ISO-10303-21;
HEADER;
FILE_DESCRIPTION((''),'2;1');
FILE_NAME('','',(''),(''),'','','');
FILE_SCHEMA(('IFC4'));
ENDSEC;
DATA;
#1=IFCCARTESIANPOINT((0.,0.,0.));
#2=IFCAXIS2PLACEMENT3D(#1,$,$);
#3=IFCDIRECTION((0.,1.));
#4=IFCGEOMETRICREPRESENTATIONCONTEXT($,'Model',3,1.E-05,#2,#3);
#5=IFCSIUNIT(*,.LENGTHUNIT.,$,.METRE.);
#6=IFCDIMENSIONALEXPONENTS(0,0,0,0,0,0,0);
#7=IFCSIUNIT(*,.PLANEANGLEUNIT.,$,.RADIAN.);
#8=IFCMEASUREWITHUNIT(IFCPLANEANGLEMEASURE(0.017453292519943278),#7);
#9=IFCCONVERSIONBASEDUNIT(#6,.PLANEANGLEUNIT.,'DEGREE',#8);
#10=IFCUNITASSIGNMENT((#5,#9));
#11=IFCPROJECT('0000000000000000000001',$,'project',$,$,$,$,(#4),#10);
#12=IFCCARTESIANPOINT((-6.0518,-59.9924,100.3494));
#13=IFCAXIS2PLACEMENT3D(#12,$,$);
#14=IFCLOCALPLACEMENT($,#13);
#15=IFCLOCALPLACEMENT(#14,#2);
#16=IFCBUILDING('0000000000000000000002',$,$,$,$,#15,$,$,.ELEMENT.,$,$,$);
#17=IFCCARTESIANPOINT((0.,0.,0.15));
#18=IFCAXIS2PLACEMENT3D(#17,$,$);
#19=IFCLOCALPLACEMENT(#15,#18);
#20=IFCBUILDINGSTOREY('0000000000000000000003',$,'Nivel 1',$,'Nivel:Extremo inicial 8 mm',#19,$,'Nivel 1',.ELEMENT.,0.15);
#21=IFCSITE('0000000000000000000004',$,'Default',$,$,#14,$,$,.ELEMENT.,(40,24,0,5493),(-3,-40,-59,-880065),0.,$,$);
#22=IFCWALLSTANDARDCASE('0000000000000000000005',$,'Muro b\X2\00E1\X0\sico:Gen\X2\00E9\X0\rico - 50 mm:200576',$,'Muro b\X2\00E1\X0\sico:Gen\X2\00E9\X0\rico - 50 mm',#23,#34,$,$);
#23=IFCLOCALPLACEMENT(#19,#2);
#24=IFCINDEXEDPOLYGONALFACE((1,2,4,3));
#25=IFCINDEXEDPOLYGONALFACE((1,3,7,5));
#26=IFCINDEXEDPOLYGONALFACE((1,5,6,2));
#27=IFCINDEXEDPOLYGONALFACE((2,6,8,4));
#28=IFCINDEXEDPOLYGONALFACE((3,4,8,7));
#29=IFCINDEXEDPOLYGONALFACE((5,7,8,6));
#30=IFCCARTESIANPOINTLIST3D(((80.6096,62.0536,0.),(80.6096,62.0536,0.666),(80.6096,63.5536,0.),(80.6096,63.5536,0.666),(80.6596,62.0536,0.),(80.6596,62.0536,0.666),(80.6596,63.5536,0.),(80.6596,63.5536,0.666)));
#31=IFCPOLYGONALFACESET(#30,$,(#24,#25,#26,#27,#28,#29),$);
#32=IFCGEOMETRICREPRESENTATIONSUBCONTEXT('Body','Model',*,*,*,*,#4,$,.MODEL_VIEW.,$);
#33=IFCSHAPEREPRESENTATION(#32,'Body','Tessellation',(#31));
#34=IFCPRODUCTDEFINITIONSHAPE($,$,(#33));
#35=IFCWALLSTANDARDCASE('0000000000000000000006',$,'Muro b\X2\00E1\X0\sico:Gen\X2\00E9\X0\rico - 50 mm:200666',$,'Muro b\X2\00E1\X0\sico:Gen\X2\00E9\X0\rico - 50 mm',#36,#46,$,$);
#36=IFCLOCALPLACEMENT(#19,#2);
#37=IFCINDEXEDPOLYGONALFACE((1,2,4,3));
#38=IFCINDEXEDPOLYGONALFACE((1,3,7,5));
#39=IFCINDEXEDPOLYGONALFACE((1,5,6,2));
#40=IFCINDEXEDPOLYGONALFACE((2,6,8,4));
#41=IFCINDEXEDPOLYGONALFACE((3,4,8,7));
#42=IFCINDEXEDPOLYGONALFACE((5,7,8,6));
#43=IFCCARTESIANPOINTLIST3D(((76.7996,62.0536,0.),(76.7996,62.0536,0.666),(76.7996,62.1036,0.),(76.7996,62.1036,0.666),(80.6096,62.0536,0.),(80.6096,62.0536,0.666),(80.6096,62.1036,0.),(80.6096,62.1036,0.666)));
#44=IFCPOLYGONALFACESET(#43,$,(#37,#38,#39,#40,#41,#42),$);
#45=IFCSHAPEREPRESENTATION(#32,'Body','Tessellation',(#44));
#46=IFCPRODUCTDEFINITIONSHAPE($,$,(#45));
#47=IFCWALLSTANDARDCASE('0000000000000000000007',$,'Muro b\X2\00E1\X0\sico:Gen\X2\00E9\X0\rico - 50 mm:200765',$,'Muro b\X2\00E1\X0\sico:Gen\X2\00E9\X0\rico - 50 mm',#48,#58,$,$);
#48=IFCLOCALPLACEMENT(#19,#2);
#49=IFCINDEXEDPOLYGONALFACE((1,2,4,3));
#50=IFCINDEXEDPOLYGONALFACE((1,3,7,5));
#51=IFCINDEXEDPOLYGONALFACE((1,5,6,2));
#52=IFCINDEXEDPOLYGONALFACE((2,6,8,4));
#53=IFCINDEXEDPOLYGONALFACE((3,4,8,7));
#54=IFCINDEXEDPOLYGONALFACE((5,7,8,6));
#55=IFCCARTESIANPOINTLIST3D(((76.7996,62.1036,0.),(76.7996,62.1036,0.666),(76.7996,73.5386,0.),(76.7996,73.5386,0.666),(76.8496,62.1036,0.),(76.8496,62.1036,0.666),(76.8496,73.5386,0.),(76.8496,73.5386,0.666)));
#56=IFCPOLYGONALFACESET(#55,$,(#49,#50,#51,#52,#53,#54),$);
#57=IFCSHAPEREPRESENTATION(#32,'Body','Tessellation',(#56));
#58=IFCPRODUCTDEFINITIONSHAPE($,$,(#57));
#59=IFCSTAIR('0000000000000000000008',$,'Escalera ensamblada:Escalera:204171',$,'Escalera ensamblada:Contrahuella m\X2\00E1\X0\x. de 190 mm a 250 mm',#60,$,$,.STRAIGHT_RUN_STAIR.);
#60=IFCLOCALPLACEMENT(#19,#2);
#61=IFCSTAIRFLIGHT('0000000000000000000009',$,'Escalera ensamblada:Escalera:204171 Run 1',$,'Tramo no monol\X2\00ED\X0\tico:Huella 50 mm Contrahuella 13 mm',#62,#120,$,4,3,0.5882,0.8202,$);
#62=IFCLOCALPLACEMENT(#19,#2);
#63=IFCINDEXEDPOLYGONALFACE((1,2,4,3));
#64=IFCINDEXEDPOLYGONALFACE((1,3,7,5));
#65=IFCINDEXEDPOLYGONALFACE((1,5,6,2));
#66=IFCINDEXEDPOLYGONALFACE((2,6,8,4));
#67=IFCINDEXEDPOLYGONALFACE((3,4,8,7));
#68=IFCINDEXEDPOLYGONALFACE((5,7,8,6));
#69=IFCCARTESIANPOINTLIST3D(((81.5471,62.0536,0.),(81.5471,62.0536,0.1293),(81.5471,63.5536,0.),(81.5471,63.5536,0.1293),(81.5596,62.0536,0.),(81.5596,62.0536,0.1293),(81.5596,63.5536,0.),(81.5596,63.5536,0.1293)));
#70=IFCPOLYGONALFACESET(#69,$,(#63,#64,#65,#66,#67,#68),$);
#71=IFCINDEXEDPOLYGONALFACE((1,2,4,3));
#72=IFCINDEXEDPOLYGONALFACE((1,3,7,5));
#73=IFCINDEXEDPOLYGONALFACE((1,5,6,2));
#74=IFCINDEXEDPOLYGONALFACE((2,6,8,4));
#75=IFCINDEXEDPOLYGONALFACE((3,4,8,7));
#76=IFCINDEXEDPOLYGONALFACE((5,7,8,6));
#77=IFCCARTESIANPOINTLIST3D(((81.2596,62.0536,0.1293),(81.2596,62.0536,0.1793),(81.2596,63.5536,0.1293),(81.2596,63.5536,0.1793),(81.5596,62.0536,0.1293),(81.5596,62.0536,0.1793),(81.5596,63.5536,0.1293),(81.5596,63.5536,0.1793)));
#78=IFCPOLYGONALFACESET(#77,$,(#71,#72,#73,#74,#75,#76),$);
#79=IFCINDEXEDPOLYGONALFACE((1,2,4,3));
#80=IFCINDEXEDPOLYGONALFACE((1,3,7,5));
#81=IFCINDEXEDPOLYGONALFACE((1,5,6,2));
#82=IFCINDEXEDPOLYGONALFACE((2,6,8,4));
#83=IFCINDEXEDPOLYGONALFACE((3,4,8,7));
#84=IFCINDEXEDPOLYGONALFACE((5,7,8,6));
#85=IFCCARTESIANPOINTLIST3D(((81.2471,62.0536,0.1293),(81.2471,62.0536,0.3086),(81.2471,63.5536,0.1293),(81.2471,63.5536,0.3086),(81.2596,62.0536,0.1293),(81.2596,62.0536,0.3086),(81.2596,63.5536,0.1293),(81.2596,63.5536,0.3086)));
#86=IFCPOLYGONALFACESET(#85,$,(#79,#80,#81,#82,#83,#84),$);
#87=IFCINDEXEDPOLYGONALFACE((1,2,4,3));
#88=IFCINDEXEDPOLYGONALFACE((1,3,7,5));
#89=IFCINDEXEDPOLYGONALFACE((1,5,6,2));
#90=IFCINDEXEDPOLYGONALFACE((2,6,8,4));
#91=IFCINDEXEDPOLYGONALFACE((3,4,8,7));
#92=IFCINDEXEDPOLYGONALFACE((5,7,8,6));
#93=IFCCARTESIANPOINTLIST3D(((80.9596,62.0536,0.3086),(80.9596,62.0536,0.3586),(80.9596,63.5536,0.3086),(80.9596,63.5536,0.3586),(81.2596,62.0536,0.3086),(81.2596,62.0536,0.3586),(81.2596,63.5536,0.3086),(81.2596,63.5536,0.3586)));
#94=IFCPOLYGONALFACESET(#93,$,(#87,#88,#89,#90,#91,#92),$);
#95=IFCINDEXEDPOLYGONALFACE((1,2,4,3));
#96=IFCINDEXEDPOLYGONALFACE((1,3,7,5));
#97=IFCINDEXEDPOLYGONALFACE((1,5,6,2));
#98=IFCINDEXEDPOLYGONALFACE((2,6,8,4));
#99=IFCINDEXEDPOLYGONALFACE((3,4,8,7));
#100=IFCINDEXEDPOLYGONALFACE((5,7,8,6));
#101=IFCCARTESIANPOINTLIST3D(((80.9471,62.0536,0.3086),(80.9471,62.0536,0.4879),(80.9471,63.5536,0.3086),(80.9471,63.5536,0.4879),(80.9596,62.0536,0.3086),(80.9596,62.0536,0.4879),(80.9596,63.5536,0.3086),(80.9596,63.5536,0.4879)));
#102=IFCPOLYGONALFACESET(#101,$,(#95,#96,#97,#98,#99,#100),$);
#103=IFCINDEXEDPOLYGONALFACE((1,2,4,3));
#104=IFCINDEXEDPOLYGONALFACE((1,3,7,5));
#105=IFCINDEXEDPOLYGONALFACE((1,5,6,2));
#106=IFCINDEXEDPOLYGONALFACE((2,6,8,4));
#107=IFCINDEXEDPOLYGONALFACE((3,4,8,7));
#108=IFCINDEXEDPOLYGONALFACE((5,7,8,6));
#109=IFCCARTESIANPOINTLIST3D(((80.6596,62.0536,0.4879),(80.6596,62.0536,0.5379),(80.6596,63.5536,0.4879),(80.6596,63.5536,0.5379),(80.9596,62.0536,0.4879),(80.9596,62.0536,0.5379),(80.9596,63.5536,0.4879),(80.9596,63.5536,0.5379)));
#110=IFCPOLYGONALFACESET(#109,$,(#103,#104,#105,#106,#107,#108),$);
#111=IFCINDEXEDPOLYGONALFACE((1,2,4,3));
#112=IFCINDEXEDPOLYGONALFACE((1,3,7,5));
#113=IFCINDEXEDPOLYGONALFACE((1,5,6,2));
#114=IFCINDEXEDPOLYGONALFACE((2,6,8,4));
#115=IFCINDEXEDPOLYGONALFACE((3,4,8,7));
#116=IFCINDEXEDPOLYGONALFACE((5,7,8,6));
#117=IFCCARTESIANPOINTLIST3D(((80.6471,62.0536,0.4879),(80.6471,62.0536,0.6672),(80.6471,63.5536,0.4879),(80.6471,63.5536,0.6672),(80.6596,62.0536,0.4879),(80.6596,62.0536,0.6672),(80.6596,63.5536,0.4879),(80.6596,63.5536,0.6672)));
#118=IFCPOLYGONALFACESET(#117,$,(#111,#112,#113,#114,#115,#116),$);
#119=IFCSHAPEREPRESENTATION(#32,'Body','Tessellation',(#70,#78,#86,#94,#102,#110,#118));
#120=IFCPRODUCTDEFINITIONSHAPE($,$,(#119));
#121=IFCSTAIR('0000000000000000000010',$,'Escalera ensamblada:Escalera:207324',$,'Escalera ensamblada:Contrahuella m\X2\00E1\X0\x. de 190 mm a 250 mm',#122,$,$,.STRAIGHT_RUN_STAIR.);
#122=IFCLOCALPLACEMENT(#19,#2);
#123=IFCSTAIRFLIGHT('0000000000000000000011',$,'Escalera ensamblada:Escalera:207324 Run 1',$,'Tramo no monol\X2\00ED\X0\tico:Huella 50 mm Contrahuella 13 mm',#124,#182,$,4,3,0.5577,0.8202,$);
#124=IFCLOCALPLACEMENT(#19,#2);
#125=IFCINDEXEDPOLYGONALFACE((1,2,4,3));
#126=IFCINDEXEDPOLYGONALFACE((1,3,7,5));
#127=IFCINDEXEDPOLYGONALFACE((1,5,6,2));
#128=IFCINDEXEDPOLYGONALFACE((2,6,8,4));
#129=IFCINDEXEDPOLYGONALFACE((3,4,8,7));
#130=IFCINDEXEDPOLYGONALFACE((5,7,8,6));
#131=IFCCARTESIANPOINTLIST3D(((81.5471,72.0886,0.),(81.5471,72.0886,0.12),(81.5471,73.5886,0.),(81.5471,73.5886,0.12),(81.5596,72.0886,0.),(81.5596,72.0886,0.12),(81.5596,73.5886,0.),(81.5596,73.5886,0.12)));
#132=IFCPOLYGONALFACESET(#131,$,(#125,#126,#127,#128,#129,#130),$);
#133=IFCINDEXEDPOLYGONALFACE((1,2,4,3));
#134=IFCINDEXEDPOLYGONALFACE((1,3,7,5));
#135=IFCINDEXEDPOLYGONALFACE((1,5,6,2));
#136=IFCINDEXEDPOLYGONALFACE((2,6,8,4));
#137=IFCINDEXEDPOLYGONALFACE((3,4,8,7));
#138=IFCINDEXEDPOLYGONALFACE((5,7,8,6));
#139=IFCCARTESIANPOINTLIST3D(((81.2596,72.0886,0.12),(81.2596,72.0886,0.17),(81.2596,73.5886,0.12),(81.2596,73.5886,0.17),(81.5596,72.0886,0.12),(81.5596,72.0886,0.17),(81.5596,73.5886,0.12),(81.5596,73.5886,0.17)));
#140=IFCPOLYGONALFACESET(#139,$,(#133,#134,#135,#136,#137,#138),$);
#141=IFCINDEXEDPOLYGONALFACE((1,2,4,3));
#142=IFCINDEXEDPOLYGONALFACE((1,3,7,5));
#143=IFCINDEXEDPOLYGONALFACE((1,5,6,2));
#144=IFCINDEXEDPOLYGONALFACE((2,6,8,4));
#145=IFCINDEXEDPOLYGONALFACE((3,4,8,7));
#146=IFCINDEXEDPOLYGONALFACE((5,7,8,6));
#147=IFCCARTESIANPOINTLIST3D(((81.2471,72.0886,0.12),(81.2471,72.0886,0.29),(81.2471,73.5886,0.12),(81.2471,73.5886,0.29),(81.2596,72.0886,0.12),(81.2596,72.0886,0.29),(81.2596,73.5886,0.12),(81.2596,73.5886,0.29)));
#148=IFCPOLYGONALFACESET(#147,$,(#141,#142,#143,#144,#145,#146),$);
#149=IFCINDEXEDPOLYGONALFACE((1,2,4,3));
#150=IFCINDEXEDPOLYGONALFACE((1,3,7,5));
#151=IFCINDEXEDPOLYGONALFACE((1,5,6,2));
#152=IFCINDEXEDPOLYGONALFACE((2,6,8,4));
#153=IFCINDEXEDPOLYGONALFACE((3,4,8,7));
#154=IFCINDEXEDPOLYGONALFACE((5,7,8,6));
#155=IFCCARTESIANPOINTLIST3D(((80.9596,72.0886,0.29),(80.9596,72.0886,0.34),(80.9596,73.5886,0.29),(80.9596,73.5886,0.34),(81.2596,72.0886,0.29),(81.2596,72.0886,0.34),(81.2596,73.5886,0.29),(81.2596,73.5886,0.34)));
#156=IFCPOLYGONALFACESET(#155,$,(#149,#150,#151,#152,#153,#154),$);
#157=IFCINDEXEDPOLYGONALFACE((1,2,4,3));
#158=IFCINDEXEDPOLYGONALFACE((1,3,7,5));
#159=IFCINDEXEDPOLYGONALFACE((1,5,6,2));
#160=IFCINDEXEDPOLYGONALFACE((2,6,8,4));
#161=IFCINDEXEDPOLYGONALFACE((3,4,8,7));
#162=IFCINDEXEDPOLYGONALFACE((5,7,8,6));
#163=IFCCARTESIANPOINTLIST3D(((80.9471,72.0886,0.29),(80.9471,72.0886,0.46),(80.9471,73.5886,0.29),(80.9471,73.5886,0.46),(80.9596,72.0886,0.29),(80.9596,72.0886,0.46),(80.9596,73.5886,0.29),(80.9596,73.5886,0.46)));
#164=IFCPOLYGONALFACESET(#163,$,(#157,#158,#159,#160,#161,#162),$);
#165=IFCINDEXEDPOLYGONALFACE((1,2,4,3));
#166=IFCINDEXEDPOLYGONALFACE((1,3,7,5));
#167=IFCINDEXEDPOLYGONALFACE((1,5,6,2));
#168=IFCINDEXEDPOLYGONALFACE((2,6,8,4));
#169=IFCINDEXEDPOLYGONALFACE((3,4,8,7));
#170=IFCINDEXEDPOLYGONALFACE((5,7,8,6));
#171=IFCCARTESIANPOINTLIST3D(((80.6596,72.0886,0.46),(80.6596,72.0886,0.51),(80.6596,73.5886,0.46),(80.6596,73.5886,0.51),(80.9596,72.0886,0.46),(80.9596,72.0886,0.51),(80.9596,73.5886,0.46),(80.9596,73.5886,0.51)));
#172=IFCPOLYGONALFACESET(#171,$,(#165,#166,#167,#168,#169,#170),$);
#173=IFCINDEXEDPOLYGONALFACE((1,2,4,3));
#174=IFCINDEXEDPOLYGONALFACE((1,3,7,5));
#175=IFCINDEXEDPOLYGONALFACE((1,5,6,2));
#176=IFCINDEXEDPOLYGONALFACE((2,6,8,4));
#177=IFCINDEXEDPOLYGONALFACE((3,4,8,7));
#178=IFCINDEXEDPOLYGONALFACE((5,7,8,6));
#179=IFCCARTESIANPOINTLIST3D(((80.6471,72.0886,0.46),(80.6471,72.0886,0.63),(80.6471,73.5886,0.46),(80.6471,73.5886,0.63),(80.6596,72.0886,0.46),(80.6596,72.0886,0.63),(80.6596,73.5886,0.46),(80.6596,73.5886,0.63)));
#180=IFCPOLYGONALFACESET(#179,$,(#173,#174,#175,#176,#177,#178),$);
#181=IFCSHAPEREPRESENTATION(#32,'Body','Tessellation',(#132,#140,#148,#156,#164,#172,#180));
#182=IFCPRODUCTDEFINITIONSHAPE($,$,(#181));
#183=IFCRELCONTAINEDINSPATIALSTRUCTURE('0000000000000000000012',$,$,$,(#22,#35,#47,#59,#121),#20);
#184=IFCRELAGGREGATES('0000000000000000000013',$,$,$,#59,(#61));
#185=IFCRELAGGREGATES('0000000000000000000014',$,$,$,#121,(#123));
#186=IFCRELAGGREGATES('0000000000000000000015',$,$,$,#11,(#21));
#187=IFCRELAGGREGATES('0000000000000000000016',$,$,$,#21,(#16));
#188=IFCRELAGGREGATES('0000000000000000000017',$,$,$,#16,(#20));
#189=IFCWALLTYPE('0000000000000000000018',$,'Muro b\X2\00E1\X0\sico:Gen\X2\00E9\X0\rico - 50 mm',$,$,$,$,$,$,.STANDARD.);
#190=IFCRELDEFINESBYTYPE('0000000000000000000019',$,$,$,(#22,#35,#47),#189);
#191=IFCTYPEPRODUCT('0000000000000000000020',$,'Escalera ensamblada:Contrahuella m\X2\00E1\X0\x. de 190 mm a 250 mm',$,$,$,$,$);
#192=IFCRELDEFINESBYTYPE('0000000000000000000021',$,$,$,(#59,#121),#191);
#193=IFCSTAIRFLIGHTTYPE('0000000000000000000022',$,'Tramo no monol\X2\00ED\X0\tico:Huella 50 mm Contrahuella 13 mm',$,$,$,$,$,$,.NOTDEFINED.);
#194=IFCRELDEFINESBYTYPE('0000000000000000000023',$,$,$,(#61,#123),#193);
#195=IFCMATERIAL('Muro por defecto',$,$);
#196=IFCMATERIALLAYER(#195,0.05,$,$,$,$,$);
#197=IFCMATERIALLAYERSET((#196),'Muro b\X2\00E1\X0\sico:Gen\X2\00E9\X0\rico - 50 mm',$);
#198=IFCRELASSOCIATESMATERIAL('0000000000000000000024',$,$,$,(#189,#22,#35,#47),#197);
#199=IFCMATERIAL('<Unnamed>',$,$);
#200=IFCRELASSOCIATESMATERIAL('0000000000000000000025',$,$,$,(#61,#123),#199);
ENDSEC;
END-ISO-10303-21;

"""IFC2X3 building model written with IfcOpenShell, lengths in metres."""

from ifc_helpers import new_model, entity, si_unit, converted_unit, direction, frame, frame_2d, origin, origin_2d_with_axis, place, context, subcontext, project, spatial, polyline, rectangle, extrude, clip, bounded_halfspace, material, layer, layer_set, layer_usage, type_object, element, aggregate, save


model = new_model("IFC2X3")

# Units and contexts
model_context = context("Model", 3, precision=1e-05, world=origin(), true_north=direction((0.0, 1.0)))
body_context = subcontext(model_context, "Body", "Model", "MODEL_VIEW")
ifc_project = project(units=[si_unit("LENGTHUNIT", "METRE"), converted_unit("PLANEANGLEUNIT", "DEGREE", entity("IfcPlaneAngleMeasure", 0.017453292519943278), si_unit("PLANEANGLEUNIT", "RADIAN"), dimensions=[0, 0, 0, 0, 0, 0, 0])], contexts=[model_context])

# Site, building, storey
site_placement = place(None, frame((-6.0518, -59.9924, 100.3494)))
site = spatial("IfcSite", under=ifc_project, at=site_placement, Name="Default", CompositionType="ELEMENT", RefLatitude=(40, 24, 0, 5493), RefLongitude=(-3, -40, -59, -880065), RefElevation=0.0)
building_placement = place(site_placement, origin())
building = spatial("IfcBuilding", under=site, at=building_placement, CompositionType="ELEMENT")
storey_placement = place(building_placement, frame((0.0, 0.0, 0.15)))
storey = spatial("IfcBuildingStorey", under=building, at=storey_placement, Name="Nivel 1", ObjectType="Nivel:Extremo inicial 8 mm", LongName="Nivel 1", CompositionType="ELEMENT", Elevation=0.15)

# Walls
ifc_material_1 = material(Name="Muro por defecto")
ifc_layer_1 = layer(ifc_material_1, 0.05)
ifc_layer_set_1 = layer_set([ifc_layer_1], Name="Muro básico:Genérico - 50 mm")
wall_type = type_object("IfcWallType", Name="Muro básico:Genérico - 50 mm", PredefinedType="STANDARD", material=ifc_layer_set_1)
ifc_layer_usage_1 = layer_usage(ifc_layer_set_1, "AXIS2", "POSITIVE", -0.025)
wall_1_placement = place(storey_placement, frame((80.6346, 63.5536, 0.0), z_axis=(0.0, 0.0, 1.0), x_axis=(0.0, -1.0, 0.0)))
element("IfcWallStandardCase", 1, at=wall_1_placement, inside=storey, type_object=wall_type, material=ifc_layer_usage_1, Name="Muro básico:Genérico - 50 mm:200576", ObjectType="Muro básico:Genérico - 50 mm", context=body_context, shape_type="Clipping", body=[
    clip(extrude(rectangle(XDim=1.5, YDim=0.05, at=frame_2d((0.75, 0.0), x_axis=(-1.0, 0.0))), origin(), (0.0, 0.0, 1.0), 0.666), bounded_halfspace(frame((0.0, -0.025, 0.666), z_axis=(0.0, 0.0, -1.0), x_axis=(0.0, 1.0, 0.0)), True, frame((0.0, -0.025, 0.666), z_axis=(0.0, 0.0, -1.0), x_axis=(0.0, 1.0, 0.0)), polyline([(0.0, 0.0), (0.05, 0.0), (0.05, 1.5), (0.0, 1.5), (0.0, 0.0)]))),
])
ifc_layer_usage_2 = layer_usage(ifc_layer_set_1, "AXIS2", "POSITIVE", -0.025)
wall_2_placement = place(storey_placement, frame((80.6096, 62.0786, 0.0), z_axis=(0.0, 0.0, 1.0), x_axis=(-1.0, 0.0, 0.0)))
element("IfcWallStandardCase", 2, at=wall_2_placement, inside=storey, type_object=wall_type, material=ifc_layer_usage_2, Name="Muro básico:Genérico - 50 mm:200666", ObjectType="Muro básico:Genérico - 50 mm", context=body_context, shape_type="Clipping", body=[
    clip(extrude(rectangle(XDim=3.81, YDim=0.05, at=frame_2d((1.905, 0.0), x_axis=(-1.0, 0.0))), origin(), (0.0, 0.0, 1.0), 0.666), bounded_halfspace(frame((0.0, -0.025, 0.666), z_axis=(0.0, 0.0, -1.0), x_axis=(-1.0, 0.0, 0.0)), True, frame((0.0, -0.025, 0.666), z_axis=(0.0, 0.0, -1.0), x_axis=(-1.0, 0.0, 0.0)), polyline([(0.0, 0.0), (0.0, 0.05), (-3.81, 0.05), (-3.81, 0.0), (-3.76, 0.0), (0.0, 0.0)]))),
])
ifc_layer_usage_3 = layer_usage(ifc_layer_set_1, "AXIS2", "POSITIVE", -0.025)
wall_3_placement = place(storey_placement, frame((76.8246, 62.1036, 0.0), z_axis=(0.0, 0.0, 1.0), x_axis=(0.0, 1.0, 0.0)))
element("IfcWallStandardCase", 3, at=wall_3_placement, inside=storey, type_object=wall_type, material=ifc_layer_usage_3, Name="Muro básico:Genérico - 50 mm:200765", ObjectType="Muro básico:Genérico - 50 mm", context=body_context, shape_type="Clipping", body=[
    clip(extrude(rectangle(XDim=11.435, YDim=0.05, at=frame_2d((5.7175, 0.0), x_axis=(-1.0, 0.0))), origin(), (0.0, 0.0, 1.0), 0.666), bounded_halfspace(frame((0.0, -0.025, 0.666), z_axis=(0.0, 0.0, -1.0), x_axis=(0.0, -1.0, 0.0)), True, frame((0.0, -0.025, 0.666), z_axis=(0.0, 0.0, -1.0), x_axis=(0.0, -1.0, 0.0)), polyline([(0.0, 0.0), (-0.05, 0.0), (-0.05, -11.435), (0.0, -11.435), (0.0, 0.0)]))),
])

# Stairs, stair flights
type_product = type_object("IfcTypeProduct", Name="Escalera ensamblada:Contrahuella máx. de 190 mm a 250 mm")
stair_1_placement = place(storey_placement, origin())
stair_1 = element("IfcStair", 4, at=stair_1_placement, inside=storey, type_object=type_product, Name="Escalera ensamblada:Escalera:204171", ObjectType="Escalera ensamblada:Contrahuella máx. de 190 mm a 250 mm", ShapeType="STRAIGHT_RUN_STAIR")
ifc_material_2 = material(Name="<Unnamed>")
stair_flight_type = type_object("IfcStairFlightType", Name="Tramo no monolítico:Huella 50 mm Contrahuella 13 mm", PredefinedType="NOTDEFINED")
stair_flight_1_placement = place(stair_1_placement, origin())
stair_flight_1 = element("IfcStairFlight", 5, at=stair_flight_1_placement, type_object=stair_flight_type, material=ifc_material_2, Name="Escalera ensamblada:Escalera:204171 Run 1", ObjectType="Tramo no monolítico:Huella 50 mm Contrahuella 13 mm", NumberOfRiser=4, NumberOfTreads=3, RiserHeight=0.5882, TreadLength=0.8202, context=body_context, shape_type="SweptSolid", body=[
    extrude(rectangle(XDim=1.5, YDim=0.0125, at=origin_2d_with_axis()), frame((81.5534, 62.8036, 0.0), z_axis=(0.0, 0.0, 1.0), x_axis=(0.0, -1.0, 0.0)), (0.0, 0.0, 1.0), 0.1293),
    extrude(rectangle(XDim=0.3, YDim=1.5, at=frame_2d((0.0, 0.0), x_axis=(1.0, 0.0))), frame((81.4096, 62.8036, 0.1293)), (0.0, 0.0, 1.0), 0.05),
    extrude(rectangle(XDim=1.5, YDim=0.0125, at=origin_2d_with_axis()), frame((81.2534, 62.8036, 0.1293), z_axis=(0.0, 0.0, 1.0), x_axis=(0.0, -1.0, 0.0)), (0.0, 0.0, 1.0), 0.1793),
    extrude(rectangle(XDim=0.3, YDim=1.5, at=frame_2d((0.0, 0.0), x_axis=(1.0, 0.0))), frame((81.1096, 62.8036, 0.3086)), (0.0, 0.0, 1.0), 0.05),
    extrude(rectangle(XDim=1.5, YDim=0.0125, at=origin_2d_with_axis()), frame((80.9534, 62.8036, 0.3086), z_axis=(0.0, 0.0, 1.0), x_axis=(0.0, -1.0, 0.0)), (0.0, 0.0, 1.0), 0.1793),
    extrude(rectangle(XDim=0.3, YDim=1.5, at=frame_2d((0.0, 0.0), x_axis=(1.0, 0.0))), frame((80.8096, 62.8036, 0.4879)), (0.0, 0.0, 1.0), 0.05),
    extrude(rectangle(XDim=1.5, YDim=0.0125, at=origin_2d_with_axis()), frame((80.6534, 62.8036, 0.4879), z_axis=(0.0, 0.0, 1.0), x_axis=(0.0, -1.0, 0.0)), (0.0, 0.0, 1.0), 0.1793),
])
aggregate(stair_1, [stair_flight_1])
stair_2_placement = place(storey_placement, origin())
stair_2 = element("IfcStair", 6, at=stair_2_placement, inside=storey, type_object=type_product, Name="Escalera ensamblada:Escalera:207324", ObjectType="Escalera ensamblada:Contrahuella máx. de 190 mm a 250 mm", ShapeType="STRAIGHT_RUN_STAIR")
stair_flight_2_placement = place(stair_2_placement, origin())
stair_flight_2 = element("IfcStairFlight", 7, at=stair_flight_2_placement, type_object=stair_flight_type, material=ifc_material_2, Name="Escalera ensamblada:Escalera:207324 Run 1", ObjectType="Tramo no monolítico:Huella 50 mm Contrahuella 13 mm", NumberOfRiser=4, NumberOfTreads=3, RiserHeight=0.5577, TreadLength=0.8202, context=body_context, shape_type="SweptSolid", body=[
    extrude(rectangle(XDim=1.5, YDim=0.0125, at=origin_2d_with_axis()), frame((81.5534, 72.8386, 0.0), z_axis=(0.0, 0.0, 1.0), x_axis=(0.0, -1.0, 0.0)), (0.0, 0.0, 1.0), 0.12),
    extrude(rectangle(XDim=0.3, YDim=1.5, at=frame_2d((0.0, 0.0), x_axis=(1.0, 0.0))), frame((81.4096, 72.8386, 0.12)), (0.0, 0.0, 1.0), 0.05),
    extrude(rectangle(XDim=1.5, YDim=0.0125, at=origin_2d_with_axis()), frame((81.2534, 72.8386, 0.12), z_axis=(0.0, 0.0, 1.0), x_axis=(0.0, -1.0, 0.0)), (0.0, 0.0, 1.0), 0.17),
    extrude(rectangle(XDim=0.3, YDim=1.5, at=frame_2d((0.0, 0.0), x_axis=(1.0, 0.0))), frame((81.1096, 72.8386, 0.29)), (0.0, 0.0, 1.0), 0.05),
    extrude(rectangle(XDim=1.5, YDim=0.0125, at=origin_2d_with_axis()), frame((80.9534, 72.8386, 0.29), z_axis=(0.0, 0.0, 1.0), x_axis=(0.0, -1.0, 0.0)), (0.0, 0.0, 1.0), 0.17),
    extrude(rectangle(XDim=0.3, YDim=1.5, at=frame_2d((0.0, 0.0), x_axis=(1.0, 0.0))), frame((80.8096, 72.8386, 0.46)), (0.0, 0.0, 1.0), 0.05),
    extrude(rectangle(XDim=1.5, YDim=0.0125, at=origin_2d_with_axis()), frame((80.6534, 72.8386, 0.46), z_axis=(0.0, 0.0, 1.0), x_axis=(0.0, -1.0, 0.0)), (0.0, 0.0, 1.0), 0.17),
])
aggregate(stair_2, [stair_flight_2])

save(model, "model.ifc")
